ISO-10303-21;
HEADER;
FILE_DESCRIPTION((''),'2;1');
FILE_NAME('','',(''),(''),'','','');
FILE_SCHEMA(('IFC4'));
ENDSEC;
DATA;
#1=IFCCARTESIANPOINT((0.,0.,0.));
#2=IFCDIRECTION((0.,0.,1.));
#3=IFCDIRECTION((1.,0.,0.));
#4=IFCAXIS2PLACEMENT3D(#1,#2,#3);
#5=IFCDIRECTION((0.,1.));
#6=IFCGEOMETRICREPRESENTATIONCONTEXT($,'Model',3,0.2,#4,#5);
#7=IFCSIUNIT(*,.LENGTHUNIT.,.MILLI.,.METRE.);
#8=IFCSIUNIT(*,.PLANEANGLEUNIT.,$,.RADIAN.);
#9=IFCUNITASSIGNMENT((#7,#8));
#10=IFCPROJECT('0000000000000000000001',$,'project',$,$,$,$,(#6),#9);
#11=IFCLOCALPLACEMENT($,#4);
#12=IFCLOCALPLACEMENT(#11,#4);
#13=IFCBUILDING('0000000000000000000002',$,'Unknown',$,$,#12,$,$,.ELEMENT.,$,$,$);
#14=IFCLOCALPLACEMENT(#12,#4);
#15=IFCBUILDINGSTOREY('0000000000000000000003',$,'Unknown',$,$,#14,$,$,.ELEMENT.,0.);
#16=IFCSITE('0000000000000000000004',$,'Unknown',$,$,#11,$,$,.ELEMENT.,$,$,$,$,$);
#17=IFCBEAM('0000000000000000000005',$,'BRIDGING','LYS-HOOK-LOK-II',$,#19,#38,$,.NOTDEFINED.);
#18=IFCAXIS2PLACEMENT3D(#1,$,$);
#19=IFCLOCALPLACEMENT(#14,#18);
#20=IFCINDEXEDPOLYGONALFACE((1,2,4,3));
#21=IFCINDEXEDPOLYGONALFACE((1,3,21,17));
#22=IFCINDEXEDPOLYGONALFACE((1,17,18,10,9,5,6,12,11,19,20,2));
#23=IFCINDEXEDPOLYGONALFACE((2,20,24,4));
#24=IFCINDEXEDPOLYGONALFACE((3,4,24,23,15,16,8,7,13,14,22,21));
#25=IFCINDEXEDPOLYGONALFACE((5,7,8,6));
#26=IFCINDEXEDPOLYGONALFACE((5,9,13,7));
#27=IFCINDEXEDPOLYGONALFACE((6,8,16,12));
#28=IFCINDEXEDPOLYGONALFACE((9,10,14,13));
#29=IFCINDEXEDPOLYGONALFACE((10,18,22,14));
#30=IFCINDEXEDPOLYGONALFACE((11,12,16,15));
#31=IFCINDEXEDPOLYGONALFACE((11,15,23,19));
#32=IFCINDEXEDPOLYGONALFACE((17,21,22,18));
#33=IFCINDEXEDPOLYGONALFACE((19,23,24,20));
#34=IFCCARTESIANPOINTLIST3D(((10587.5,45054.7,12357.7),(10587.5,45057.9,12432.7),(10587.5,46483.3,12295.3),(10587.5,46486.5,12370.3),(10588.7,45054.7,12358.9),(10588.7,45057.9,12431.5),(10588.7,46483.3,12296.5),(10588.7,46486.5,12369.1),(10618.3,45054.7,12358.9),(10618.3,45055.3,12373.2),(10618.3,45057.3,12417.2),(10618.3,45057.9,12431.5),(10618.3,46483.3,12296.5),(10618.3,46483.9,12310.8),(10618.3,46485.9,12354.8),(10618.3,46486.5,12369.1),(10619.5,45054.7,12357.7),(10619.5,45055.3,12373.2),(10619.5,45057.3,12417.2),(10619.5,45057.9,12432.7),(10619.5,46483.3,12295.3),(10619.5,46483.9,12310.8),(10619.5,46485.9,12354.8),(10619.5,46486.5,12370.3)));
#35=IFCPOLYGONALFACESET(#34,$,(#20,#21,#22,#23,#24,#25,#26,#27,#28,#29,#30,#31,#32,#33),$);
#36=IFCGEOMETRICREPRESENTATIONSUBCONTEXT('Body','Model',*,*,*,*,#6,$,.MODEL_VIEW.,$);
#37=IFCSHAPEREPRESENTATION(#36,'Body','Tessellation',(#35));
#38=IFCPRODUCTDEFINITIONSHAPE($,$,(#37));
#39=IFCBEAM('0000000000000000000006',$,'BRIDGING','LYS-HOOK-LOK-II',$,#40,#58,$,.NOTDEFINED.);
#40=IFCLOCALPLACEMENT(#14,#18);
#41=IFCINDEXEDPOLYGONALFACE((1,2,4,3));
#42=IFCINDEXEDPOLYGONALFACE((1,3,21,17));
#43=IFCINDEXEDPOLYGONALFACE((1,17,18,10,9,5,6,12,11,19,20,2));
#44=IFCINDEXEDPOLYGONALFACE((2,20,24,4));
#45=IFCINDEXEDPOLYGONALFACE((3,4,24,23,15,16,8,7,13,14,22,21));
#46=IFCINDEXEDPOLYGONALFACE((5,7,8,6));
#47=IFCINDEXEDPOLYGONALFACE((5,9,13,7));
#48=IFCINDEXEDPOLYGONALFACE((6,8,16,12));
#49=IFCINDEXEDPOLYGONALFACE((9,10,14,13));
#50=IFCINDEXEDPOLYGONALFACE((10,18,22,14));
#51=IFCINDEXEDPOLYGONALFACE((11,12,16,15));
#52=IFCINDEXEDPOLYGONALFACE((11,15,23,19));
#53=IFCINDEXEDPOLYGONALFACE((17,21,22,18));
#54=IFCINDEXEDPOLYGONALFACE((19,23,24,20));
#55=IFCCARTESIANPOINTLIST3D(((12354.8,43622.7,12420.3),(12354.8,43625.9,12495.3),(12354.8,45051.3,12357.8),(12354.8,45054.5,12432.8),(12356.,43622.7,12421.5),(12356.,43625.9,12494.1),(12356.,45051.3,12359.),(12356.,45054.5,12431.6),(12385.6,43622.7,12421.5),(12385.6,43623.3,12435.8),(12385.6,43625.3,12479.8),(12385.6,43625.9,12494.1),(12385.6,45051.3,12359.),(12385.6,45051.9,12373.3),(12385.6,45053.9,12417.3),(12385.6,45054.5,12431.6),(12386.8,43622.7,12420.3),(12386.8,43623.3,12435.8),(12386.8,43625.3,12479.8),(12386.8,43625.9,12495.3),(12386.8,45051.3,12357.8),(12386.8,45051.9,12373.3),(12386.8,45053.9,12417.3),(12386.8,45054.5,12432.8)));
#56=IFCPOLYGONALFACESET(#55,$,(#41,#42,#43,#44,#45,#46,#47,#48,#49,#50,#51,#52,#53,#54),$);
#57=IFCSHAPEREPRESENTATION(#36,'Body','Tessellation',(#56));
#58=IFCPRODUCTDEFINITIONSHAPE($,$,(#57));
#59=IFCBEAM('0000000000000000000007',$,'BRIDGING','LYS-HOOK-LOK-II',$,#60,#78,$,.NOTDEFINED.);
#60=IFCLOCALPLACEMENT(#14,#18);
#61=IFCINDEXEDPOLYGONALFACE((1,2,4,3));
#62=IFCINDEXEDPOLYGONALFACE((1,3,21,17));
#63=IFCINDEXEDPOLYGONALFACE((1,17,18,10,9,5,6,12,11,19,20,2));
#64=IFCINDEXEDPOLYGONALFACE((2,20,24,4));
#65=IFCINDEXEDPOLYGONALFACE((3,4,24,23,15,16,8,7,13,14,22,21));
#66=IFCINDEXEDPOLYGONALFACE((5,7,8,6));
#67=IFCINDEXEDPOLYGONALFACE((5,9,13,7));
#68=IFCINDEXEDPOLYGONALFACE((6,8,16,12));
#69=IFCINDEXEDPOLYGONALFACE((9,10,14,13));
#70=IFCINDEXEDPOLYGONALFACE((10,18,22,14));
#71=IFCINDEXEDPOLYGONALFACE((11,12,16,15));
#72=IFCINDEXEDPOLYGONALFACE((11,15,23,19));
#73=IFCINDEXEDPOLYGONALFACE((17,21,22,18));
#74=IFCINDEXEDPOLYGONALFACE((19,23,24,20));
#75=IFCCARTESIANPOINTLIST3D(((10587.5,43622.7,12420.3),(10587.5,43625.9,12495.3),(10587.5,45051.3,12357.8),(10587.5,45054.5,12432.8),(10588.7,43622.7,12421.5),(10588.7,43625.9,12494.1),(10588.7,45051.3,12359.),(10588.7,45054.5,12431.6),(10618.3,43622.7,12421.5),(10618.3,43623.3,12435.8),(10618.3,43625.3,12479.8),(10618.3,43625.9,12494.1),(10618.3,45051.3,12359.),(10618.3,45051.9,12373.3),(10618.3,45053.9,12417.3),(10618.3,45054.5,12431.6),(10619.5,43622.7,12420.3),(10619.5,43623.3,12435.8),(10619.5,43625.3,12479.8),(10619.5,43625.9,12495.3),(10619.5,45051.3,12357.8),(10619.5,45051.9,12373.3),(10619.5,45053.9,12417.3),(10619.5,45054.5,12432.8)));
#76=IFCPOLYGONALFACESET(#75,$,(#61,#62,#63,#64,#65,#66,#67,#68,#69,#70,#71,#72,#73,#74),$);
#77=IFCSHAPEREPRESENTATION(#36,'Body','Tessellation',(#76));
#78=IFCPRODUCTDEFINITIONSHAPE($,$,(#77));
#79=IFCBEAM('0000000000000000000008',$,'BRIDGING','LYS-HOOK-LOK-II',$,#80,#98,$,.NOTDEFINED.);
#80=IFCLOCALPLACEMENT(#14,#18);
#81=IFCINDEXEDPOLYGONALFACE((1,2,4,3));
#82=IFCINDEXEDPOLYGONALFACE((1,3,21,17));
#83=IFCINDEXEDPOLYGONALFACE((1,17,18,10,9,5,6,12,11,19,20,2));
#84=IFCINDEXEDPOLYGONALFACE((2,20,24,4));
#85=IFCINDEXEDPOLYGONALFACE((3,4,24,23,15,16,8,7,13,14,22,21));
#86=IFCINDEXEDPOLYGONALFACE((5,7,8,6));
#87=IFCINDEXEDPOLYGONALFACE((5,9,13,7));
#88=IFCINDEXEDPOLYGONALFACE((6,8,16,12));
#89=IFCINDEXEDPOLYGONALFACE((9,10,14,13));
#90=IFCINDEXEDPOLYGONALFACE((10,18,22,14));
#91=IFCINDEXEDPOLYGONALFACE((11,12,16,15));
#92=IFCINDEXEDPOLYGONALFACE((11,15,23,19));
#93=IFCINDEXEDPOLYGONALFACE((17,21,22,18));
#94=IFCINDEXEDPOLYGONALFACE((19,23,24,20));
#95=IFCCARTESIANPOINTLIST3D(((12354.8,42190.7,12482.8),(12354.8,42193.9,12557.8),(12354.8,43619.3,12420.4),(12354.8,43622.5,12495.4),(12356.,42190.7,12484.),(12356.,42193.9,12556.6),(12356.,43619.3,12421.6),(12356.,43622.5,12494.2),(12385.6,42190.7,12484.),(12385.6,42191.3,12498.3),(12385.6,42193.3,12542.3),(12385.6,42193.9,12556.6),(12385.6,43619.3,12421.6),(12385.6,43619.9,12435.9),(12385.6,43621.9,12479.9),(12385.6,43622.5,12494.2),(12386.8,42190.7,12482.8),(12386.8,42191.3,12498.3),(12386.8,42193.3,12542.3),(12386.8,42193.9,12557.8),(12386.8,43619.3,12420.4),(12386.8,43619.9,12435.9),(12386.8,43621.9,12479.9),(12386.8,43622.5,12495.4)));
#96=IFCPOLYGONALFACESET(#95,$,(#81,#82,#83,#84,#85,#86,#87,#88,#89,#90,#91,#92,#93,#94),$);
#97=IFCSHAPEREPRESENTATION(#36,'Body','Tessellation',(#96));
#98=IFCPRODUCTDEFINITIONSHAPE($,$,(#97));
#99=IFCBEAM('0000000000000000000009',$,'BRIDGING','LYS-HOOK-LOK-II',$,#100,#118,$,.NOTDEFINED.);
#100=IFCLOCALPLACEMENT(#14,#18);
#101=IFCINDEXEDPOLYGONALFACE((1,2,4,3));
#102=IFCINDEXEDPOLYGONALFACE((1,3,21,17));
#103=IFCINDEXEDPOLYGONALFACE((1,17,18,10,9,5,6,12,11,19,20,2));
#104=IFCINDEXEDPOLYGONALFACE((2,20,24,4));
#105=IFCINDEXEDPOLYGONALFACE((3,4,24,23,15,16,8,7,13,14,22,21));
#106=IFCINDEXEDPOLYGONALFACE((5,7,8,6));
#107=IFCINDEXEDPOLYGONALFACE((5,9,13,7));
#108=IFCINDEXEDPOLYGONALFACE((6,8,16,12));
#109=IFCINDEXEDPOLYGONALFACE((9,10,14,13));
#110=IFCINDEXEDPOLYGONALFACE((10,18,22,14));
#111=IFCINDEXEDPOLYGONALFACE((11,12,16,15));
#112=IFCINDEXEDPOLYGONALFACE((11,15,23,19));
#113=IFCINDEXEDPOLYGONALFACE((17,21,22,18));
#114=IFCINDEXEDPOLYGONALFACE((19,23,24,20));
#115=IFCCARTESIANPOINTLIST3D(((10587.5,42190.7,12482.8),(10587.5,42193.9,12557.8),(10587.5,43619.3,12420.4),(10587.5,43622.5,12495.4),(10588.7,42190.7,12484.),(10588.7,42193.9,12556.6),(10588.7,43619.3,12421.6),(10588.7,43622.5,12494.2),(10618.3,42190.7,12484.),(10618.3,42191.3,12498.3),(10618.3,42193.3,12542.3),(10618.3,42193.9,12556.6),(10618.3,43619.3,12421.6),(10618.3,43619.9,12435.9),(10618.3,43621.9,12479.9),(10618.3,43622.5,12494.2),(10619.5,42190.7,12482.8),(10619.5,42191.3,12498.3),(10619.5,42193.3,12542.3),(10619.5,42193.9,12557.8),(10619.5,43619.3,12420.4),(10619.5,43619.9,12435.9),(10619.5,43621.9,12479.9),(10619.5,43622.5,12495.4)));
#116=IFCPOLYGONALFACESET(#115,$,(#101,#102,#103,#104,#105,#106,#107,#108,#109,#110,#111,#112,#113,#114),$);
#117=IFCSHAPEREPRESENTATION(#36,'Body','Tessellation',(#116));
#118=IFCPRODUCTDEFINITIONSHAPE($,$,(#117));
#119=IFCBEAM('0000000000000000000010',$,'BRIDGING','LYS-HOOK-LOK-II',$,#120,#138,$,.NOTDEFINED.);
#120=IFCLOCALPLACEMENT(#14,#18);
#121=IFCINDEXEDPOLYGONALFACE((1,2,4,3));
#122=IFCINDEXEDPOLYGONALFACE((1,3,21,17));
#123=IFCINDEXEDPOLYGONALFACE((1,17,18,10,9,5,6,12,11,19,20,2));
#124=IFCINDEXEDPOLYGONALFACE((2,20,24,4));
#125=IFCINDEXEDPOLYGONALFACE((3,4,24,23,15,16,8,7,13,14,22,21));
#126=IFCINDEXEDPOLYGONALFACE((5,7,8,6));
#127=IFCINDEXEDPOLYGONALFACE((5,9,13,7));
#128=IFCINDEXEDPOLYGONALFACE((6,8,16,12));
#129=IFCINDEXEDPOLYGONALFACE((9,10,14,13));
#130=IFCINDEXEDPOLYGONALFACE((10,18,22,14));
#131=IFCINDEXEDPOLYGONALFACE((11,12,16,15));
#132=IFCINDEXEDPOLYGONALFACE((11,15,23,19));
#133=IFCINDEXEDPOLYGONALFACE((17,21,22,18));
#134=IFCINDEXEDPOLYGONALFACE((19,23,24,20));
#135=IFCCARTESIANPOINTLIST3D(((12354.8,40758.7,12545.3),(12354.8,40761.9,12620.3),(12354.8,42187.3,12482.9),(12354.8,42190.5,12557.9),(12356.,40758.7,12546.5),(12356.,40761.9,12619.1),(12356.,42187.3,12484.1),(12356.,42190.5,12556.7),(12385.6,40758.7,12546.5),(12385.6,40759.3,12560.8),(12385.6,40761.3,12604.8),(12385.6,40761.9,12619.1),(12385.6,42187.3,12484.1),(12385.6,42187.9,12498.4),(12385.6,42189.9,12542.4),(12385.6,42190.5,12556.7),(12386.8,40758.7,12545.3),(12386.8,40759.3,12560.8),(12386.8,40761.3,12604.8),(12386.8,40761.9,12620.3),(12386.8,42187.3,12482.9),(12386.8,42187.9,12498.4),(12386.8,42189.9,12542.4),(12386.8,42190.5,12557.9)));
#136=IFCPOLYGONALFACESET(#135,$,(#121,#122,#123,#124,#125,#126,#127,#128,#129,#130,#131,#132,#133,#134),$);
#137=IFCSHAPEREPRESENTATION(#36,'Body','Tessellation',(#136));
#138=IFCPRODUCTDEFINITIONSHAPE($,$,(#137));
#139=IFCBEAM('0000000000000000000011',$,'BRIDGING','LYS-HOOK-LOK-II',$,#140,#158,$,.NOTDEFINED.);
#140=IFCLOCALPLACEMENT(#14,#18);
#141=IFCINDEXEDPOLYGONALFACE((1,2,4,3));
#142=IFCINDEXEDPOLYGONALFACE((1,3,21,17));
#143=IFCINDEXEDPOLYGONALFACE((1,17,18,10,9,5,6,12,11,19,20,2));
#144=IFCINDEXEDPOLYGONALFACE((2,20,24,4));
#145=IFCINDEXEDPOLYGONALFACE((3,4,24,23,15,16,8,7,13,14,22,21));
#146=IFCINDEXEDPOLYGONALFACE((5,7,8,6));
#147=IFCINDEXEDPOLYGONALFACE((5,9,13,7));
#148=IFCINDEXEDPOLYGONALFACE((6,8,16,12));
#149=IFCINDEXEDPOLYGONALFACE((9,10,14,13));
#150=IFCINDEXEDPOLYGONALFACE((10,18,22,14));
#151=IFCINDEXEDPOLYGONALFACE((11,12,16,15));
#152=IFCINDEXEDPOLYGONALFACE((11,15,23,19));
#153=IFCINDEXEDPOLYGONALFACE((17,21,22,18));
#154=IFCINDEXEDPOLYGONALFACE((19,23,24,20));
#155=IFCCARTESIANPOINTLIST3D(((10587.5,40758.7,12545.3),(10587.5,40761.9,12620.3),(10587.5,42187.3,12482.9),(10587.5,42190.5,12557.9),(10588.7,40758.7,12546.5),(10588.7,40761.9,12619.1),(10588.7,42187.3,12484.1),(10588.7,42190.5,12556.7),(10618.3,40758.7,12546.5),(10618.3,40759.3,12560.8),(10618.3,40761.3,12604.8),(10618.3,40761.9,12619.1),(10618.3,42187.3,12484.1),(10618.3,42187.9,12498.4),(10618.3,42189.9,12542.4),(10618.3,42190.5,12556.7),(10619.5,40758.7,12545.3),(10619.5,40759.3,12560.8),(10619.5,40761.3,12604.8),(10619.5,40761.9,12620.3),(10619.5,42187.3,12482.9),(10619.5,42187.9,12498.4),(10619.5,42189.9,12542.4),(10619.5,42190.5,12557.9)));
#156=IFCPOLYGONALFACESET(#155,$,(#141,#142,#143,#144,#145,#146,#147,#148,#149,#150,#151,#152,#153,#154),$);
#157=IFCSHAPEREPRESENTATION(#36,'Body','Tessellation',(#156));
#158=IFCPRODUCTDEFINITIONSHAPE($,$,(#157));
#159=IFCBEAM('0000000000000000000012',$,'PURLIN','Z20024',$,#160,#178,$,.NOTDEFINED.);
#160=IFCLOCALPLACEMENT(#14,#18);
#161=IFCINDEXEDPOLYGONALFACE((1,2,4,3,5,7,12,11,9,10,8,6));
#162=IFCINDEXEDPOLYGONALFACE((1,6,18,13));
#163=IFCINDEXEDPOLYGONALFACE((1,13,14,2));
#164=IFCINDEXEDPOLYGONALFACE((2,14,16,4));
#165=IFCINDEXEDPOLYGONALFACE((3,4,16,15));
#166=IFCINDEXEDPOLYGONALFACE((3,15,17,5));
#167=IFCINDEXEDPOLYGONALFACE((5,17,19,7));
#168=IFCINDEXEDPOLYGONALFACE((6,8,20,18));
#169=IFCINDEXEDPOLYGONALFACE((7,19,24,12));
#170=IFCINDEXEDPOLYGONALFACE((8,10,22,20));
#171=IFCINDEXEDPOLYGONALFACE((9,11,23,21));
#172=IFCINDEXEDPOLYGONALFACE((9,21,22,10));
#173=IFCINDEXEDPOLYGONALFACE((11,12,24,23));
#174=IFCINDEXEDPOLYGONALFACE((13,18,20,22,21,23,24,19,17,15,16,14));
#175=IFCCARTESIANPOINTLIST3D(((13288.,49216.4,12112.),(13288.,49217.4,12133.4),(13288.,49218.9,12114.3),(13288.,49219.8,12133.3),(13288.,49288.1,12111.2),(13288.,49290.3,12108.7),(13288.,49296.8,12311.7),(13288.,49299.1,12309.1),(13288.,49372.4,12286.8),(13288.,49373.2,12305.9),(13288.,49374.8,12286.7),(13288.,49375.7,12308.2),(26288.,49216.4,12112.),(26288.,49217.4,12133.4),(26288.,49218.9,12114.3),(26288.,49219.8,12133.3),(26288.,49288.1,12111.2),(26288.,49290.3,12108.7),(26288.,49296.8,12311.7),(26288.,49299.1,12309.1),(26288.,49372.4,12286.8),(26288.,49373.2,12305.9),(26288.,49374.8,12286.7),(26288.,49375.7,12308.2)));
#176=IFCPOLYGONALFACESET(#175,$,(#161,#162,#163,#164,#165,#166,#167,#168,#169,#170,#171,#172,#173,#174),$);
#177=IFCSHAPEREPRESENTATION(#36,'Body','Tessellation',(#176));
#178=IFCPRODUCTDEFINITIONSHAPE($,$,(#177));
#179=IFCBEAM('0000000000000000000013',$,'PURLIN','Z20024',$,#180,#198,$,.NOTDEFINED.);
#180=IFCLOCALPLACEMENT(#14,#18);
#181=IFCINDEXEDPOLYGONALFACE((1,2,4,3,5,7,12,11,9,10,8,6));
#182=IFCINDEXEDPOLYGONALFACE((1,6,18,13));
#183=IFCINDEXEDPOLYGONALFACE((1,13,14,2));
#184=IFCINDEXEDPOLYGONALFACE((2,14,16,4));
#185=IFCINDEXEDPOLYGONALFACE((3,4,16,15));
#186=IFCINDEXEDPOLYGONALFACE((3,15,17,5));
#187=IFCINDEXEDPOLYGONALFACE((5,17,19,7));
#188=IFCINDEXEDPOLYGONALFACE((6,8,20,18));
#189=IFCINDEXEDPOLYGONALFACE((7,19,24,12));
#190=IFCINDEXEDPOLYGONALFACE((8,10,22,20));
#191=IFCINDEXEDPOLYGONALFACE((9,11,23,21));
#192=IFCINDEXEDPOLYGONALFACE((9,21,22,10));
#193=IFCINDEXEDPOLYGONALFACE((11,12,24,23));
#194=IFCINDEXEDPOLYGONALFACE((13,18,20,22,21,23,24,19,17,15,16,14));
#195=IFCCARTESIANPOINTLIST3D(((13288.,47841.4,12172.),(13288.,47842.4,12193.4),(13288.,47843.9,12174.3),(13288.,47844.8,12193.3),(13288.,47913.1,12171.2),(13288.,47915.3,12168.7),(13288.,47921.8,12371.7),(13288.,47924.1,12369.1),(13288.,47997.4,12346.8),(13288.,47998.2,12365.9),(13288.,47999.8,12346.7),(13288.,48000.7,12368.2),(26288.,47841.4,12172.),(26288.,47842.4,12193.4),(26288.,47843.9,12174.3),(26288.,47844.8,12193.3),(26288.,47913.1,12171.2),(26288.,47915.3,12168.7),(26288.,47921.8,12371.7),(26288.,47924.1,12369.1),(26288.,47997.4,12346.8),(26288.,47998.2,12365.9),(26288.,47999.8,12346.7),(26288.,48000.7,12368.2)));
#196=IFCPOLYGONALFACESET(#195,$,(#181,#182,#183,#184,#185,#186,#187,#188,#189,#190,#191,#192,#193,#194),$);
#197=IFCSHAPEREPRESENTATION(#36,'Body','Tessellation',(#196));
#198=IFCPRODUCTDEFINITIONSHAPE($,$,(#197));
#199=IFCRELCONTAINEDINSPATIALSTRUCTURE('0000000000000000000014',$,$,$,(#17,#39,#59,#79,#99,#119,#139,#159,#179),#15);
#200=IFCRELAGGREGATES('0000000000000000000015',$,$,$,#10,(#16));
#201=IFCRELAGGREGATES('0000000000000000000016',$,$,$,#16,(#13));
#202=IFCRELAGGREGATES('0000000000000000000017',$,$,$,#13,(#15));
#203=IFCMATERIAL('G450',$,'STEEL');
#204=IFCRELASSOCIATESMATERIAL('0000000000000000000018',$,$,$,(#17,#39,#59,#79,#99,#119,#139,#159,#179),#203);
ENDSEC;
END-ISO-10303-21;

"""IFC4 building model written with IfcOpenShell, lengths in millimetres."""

from ifc_helpers import new_model, si_unit, direction, frame, origin_with_axes, place, context, subcontext, project, spatial, line, indexed_curve, outline, extrude, material, element, save


model = new_model("IFC4")

# Units and contexts
model_context = context("Model", 3, precision=0.2, world=origin_with_axes(), true_north=direction((0.0, 1.0)))
body_context = subcontext(model_context, "Body", "Model", "MODEL_VIEW")
ifc_project = project(units=[si_unit("LENGTHUNIT", "METRE", prefix="MILLI"), si_unit("PLANEANGLEUNIT", "RADIAN")], contexts=[model_context])

# Site, building, storey
site_placement = place(None, origin_with_axes())
site = spatial("IfcSite", under=ifc_project, at=site_placement, Name="Unknown", CompositionType="ELEMENT")
building_placement = place(site_placement, origin_with_axes())
building = spatial("IfcBuilding", under=site, at=building_placement, Name="Unknown", CompositionType="ELEMENT")
storey_placement = place(building_placement, origin_with_axes())
storey = spatial("IfcBuildingStorey", under=building, at=storey_placement, Name="Unknown", CompositionType="ELEMENT", Elevation=0.0)

# Beams
ifc_material_1 = material(Name="G450", Category="STEEL")
for number, where, z_axis, x_axis, name in (
    (1, (10603.5, 45056.3, 12395.2), (1.0, 0.0, 0.0), (0.0, 0.999047, -0.043638), "BRIDGING"),
):
    element("IfcBeam", number, at=place(storey_placement, frame(where, z_axis=z_axis, x_axis=x_axis)), inside=storey, material=ifc_material_1, Name=name, Description="LYS-HOOK-LOK-II", PredefinedType="NOTDEFINED", context=body_context, shape_type="SolidModel", body=[
        extrude(outline(indexed_curve([(16.0, -37.5), (16.0, -22.0), (14.8, -22.0), (14.8, -36.3), (-14.8, -36.3), (-14.8, 36.3), (14.8, 36.3), (14.8, 22.0), (16.0, 22.0), (16.0, 37.5), (-16.0, 37.5), (-16.0, -37.5)], segments=[line(1, 2, 3, 4, 5, 6, 7, 8, 9, 10, 11, 12, 1)])), frame((0.0, 0.0, 0.0), z_axis=(-1.0, 0.0, 0.0), x_axis=(0.0, 0.0, 1.0)), (0.0, 0.0, -1.0), 1430.0),
    ])
for number, where, z_axis, x_axis, name in (
    (2, (12370.8, 43624.3, 12457.8), (1.0, 0.0, 0.0), (0.0, 0.999044, -0.043707), "BRIDGING"),
    (3, (10603.5, 43624.3, 12457.8), (1.0, 0.0, 0.0), (0.0, 0.999044, -0.043707), "BRIDGING"),
):
    element("IfcBeam", number, at=place(storey_placement, frame(where, z_axis=z_axis, x_axis=x_axis)), inside=storey, material=ifc_material_1, Name=name, Description="LYS-HOOK-LOK-II", PredefinedType="NOTDEFINED", context=body_context, shape_type="SolidModel", body=[
        extrude(outline(indexed_curve([(16.0, -37.5), (16.0, -22.0), (14.8, -22.0), (14.8, -36.3), (-14.8, -36.3), (-14.8, 36.3), (14.8, 36.3), (14.8, 22.0), (16.0, 22.0), (16.0, 37.5), (-16.0, 37.5), (-16.0, -37.5)], segments=[line(1, 2, 3, 4, 5, 6, 7, 8, 9, 10, 11, 12, 1)])), frame((0.0, 0.0, 0.0), z_axis=(-1.0, 0.0, 0.0), x_axis=(0.0, 0.0, 1.0)), (0.0, 0.0, -1.0), 1430.0),
    ])
for number, where, z_axis, x_axis, name in (
    (4, (12370.8, 42192.3, 12520.3), (1.0, 0.0, 0.0), (0.0, 0.999047, -0.043638), "BRIDGING"),
    (5, (10603.5, 42192.3, 12520.3), (1.0, 0.0, 0.0), (0.0, 0.999047, -0.043638), "BRIDGING"),
    (6, (12370.8, 40760.3, 12582.8), (1.0, 0.0, 0.0), (0.0, 0.999047, -0.043638), "BRIDGING"),
    (7, (10603.5, 40760.3, 12582.8), (1.0, 0.0, 0.0), (0.0, 0.999047, -0.043638), "BRIDGING"),
):
    element("IfcBeam", number, at=place(storey_placement, frame(where, z_axis=z_axis, x_axis=x_axis)), inside=storey, material=ifc_material_1, Name=name, Description="LYS-HOOK-LOK-II", PredefinedType="NOTDEFINED", context=body_context, shape_type="SolidModel", body=[
        extrude(outline(indexed_curve([(16.0, -37.5), (16.0, -22.0), (14.8, -22.0), (14.8, -36.3), (-14.8, -36.3), (-14.8, 36.3), (14.8, 36.3), (14.8, 22.0), (16.0, 22.0), (16.0, 37.5), (-16.0, 37.5), (-16.0, -37.5)], segments=[line(1, 2, 3, 4, 5, 6, 7, 8, 9, 10, 11, 12, 1)])), frame((0.0, 0.0, 0.0), z_axis=(-1.0, 0.0, 0.0), x_axis=(0.0, 0.0, 1.0)), (0.0, 0.0, -1.0), 1430.0),
    ])
for number, where, z_axis, x_axis, name in (
    (8, (13288.0, 49293.6, 12210.2), (0.0, -0.999048, 0.043619), (1.0, 0.0, 0.0), "PURLIN"),
    (9, (13288.0, 47918.6, 12270.2), (0.0, -0.999048, 0.043619), (1.0, 0.0, 0.0), "PURLIN"),
):
    element("IfcBeam", number, at=place(storey_placement, frame(where, z_axis=z_axis, x_axis=x_axis)), inside=storey, material=ifc_material_1, Name=name, Description="Z20024", PredefinedType="NOTDEFINED", context=body_context, shape_type="SolidModel", body=[
        extrude(outline(indexed_curve([(72.8, -101.5), (72.8, -80.0), (70.4, -80.0), (70.4, -99.1), (1.2, -99.1), (1.2, 101.5), (-77.8, 101.5), (-77.8, 80.0), (-75.4, 80.0), (-75.4, 99.1), (-1.2, 99.1), (-1.2, -101.5)], segments=[line(1, 2, 3, 4, 5, 6, 7, 8, 9, 10, 11, 12, 1)])), frame((0.0, 0.0, 0.0), z_axis=(-1.0, 0.0, 0.0), x_axis=(0.0, 0.0, 1.0)), (0.0, 0.0, -1.0), 13000.0),
    ])

save(model, "model.ifc")
